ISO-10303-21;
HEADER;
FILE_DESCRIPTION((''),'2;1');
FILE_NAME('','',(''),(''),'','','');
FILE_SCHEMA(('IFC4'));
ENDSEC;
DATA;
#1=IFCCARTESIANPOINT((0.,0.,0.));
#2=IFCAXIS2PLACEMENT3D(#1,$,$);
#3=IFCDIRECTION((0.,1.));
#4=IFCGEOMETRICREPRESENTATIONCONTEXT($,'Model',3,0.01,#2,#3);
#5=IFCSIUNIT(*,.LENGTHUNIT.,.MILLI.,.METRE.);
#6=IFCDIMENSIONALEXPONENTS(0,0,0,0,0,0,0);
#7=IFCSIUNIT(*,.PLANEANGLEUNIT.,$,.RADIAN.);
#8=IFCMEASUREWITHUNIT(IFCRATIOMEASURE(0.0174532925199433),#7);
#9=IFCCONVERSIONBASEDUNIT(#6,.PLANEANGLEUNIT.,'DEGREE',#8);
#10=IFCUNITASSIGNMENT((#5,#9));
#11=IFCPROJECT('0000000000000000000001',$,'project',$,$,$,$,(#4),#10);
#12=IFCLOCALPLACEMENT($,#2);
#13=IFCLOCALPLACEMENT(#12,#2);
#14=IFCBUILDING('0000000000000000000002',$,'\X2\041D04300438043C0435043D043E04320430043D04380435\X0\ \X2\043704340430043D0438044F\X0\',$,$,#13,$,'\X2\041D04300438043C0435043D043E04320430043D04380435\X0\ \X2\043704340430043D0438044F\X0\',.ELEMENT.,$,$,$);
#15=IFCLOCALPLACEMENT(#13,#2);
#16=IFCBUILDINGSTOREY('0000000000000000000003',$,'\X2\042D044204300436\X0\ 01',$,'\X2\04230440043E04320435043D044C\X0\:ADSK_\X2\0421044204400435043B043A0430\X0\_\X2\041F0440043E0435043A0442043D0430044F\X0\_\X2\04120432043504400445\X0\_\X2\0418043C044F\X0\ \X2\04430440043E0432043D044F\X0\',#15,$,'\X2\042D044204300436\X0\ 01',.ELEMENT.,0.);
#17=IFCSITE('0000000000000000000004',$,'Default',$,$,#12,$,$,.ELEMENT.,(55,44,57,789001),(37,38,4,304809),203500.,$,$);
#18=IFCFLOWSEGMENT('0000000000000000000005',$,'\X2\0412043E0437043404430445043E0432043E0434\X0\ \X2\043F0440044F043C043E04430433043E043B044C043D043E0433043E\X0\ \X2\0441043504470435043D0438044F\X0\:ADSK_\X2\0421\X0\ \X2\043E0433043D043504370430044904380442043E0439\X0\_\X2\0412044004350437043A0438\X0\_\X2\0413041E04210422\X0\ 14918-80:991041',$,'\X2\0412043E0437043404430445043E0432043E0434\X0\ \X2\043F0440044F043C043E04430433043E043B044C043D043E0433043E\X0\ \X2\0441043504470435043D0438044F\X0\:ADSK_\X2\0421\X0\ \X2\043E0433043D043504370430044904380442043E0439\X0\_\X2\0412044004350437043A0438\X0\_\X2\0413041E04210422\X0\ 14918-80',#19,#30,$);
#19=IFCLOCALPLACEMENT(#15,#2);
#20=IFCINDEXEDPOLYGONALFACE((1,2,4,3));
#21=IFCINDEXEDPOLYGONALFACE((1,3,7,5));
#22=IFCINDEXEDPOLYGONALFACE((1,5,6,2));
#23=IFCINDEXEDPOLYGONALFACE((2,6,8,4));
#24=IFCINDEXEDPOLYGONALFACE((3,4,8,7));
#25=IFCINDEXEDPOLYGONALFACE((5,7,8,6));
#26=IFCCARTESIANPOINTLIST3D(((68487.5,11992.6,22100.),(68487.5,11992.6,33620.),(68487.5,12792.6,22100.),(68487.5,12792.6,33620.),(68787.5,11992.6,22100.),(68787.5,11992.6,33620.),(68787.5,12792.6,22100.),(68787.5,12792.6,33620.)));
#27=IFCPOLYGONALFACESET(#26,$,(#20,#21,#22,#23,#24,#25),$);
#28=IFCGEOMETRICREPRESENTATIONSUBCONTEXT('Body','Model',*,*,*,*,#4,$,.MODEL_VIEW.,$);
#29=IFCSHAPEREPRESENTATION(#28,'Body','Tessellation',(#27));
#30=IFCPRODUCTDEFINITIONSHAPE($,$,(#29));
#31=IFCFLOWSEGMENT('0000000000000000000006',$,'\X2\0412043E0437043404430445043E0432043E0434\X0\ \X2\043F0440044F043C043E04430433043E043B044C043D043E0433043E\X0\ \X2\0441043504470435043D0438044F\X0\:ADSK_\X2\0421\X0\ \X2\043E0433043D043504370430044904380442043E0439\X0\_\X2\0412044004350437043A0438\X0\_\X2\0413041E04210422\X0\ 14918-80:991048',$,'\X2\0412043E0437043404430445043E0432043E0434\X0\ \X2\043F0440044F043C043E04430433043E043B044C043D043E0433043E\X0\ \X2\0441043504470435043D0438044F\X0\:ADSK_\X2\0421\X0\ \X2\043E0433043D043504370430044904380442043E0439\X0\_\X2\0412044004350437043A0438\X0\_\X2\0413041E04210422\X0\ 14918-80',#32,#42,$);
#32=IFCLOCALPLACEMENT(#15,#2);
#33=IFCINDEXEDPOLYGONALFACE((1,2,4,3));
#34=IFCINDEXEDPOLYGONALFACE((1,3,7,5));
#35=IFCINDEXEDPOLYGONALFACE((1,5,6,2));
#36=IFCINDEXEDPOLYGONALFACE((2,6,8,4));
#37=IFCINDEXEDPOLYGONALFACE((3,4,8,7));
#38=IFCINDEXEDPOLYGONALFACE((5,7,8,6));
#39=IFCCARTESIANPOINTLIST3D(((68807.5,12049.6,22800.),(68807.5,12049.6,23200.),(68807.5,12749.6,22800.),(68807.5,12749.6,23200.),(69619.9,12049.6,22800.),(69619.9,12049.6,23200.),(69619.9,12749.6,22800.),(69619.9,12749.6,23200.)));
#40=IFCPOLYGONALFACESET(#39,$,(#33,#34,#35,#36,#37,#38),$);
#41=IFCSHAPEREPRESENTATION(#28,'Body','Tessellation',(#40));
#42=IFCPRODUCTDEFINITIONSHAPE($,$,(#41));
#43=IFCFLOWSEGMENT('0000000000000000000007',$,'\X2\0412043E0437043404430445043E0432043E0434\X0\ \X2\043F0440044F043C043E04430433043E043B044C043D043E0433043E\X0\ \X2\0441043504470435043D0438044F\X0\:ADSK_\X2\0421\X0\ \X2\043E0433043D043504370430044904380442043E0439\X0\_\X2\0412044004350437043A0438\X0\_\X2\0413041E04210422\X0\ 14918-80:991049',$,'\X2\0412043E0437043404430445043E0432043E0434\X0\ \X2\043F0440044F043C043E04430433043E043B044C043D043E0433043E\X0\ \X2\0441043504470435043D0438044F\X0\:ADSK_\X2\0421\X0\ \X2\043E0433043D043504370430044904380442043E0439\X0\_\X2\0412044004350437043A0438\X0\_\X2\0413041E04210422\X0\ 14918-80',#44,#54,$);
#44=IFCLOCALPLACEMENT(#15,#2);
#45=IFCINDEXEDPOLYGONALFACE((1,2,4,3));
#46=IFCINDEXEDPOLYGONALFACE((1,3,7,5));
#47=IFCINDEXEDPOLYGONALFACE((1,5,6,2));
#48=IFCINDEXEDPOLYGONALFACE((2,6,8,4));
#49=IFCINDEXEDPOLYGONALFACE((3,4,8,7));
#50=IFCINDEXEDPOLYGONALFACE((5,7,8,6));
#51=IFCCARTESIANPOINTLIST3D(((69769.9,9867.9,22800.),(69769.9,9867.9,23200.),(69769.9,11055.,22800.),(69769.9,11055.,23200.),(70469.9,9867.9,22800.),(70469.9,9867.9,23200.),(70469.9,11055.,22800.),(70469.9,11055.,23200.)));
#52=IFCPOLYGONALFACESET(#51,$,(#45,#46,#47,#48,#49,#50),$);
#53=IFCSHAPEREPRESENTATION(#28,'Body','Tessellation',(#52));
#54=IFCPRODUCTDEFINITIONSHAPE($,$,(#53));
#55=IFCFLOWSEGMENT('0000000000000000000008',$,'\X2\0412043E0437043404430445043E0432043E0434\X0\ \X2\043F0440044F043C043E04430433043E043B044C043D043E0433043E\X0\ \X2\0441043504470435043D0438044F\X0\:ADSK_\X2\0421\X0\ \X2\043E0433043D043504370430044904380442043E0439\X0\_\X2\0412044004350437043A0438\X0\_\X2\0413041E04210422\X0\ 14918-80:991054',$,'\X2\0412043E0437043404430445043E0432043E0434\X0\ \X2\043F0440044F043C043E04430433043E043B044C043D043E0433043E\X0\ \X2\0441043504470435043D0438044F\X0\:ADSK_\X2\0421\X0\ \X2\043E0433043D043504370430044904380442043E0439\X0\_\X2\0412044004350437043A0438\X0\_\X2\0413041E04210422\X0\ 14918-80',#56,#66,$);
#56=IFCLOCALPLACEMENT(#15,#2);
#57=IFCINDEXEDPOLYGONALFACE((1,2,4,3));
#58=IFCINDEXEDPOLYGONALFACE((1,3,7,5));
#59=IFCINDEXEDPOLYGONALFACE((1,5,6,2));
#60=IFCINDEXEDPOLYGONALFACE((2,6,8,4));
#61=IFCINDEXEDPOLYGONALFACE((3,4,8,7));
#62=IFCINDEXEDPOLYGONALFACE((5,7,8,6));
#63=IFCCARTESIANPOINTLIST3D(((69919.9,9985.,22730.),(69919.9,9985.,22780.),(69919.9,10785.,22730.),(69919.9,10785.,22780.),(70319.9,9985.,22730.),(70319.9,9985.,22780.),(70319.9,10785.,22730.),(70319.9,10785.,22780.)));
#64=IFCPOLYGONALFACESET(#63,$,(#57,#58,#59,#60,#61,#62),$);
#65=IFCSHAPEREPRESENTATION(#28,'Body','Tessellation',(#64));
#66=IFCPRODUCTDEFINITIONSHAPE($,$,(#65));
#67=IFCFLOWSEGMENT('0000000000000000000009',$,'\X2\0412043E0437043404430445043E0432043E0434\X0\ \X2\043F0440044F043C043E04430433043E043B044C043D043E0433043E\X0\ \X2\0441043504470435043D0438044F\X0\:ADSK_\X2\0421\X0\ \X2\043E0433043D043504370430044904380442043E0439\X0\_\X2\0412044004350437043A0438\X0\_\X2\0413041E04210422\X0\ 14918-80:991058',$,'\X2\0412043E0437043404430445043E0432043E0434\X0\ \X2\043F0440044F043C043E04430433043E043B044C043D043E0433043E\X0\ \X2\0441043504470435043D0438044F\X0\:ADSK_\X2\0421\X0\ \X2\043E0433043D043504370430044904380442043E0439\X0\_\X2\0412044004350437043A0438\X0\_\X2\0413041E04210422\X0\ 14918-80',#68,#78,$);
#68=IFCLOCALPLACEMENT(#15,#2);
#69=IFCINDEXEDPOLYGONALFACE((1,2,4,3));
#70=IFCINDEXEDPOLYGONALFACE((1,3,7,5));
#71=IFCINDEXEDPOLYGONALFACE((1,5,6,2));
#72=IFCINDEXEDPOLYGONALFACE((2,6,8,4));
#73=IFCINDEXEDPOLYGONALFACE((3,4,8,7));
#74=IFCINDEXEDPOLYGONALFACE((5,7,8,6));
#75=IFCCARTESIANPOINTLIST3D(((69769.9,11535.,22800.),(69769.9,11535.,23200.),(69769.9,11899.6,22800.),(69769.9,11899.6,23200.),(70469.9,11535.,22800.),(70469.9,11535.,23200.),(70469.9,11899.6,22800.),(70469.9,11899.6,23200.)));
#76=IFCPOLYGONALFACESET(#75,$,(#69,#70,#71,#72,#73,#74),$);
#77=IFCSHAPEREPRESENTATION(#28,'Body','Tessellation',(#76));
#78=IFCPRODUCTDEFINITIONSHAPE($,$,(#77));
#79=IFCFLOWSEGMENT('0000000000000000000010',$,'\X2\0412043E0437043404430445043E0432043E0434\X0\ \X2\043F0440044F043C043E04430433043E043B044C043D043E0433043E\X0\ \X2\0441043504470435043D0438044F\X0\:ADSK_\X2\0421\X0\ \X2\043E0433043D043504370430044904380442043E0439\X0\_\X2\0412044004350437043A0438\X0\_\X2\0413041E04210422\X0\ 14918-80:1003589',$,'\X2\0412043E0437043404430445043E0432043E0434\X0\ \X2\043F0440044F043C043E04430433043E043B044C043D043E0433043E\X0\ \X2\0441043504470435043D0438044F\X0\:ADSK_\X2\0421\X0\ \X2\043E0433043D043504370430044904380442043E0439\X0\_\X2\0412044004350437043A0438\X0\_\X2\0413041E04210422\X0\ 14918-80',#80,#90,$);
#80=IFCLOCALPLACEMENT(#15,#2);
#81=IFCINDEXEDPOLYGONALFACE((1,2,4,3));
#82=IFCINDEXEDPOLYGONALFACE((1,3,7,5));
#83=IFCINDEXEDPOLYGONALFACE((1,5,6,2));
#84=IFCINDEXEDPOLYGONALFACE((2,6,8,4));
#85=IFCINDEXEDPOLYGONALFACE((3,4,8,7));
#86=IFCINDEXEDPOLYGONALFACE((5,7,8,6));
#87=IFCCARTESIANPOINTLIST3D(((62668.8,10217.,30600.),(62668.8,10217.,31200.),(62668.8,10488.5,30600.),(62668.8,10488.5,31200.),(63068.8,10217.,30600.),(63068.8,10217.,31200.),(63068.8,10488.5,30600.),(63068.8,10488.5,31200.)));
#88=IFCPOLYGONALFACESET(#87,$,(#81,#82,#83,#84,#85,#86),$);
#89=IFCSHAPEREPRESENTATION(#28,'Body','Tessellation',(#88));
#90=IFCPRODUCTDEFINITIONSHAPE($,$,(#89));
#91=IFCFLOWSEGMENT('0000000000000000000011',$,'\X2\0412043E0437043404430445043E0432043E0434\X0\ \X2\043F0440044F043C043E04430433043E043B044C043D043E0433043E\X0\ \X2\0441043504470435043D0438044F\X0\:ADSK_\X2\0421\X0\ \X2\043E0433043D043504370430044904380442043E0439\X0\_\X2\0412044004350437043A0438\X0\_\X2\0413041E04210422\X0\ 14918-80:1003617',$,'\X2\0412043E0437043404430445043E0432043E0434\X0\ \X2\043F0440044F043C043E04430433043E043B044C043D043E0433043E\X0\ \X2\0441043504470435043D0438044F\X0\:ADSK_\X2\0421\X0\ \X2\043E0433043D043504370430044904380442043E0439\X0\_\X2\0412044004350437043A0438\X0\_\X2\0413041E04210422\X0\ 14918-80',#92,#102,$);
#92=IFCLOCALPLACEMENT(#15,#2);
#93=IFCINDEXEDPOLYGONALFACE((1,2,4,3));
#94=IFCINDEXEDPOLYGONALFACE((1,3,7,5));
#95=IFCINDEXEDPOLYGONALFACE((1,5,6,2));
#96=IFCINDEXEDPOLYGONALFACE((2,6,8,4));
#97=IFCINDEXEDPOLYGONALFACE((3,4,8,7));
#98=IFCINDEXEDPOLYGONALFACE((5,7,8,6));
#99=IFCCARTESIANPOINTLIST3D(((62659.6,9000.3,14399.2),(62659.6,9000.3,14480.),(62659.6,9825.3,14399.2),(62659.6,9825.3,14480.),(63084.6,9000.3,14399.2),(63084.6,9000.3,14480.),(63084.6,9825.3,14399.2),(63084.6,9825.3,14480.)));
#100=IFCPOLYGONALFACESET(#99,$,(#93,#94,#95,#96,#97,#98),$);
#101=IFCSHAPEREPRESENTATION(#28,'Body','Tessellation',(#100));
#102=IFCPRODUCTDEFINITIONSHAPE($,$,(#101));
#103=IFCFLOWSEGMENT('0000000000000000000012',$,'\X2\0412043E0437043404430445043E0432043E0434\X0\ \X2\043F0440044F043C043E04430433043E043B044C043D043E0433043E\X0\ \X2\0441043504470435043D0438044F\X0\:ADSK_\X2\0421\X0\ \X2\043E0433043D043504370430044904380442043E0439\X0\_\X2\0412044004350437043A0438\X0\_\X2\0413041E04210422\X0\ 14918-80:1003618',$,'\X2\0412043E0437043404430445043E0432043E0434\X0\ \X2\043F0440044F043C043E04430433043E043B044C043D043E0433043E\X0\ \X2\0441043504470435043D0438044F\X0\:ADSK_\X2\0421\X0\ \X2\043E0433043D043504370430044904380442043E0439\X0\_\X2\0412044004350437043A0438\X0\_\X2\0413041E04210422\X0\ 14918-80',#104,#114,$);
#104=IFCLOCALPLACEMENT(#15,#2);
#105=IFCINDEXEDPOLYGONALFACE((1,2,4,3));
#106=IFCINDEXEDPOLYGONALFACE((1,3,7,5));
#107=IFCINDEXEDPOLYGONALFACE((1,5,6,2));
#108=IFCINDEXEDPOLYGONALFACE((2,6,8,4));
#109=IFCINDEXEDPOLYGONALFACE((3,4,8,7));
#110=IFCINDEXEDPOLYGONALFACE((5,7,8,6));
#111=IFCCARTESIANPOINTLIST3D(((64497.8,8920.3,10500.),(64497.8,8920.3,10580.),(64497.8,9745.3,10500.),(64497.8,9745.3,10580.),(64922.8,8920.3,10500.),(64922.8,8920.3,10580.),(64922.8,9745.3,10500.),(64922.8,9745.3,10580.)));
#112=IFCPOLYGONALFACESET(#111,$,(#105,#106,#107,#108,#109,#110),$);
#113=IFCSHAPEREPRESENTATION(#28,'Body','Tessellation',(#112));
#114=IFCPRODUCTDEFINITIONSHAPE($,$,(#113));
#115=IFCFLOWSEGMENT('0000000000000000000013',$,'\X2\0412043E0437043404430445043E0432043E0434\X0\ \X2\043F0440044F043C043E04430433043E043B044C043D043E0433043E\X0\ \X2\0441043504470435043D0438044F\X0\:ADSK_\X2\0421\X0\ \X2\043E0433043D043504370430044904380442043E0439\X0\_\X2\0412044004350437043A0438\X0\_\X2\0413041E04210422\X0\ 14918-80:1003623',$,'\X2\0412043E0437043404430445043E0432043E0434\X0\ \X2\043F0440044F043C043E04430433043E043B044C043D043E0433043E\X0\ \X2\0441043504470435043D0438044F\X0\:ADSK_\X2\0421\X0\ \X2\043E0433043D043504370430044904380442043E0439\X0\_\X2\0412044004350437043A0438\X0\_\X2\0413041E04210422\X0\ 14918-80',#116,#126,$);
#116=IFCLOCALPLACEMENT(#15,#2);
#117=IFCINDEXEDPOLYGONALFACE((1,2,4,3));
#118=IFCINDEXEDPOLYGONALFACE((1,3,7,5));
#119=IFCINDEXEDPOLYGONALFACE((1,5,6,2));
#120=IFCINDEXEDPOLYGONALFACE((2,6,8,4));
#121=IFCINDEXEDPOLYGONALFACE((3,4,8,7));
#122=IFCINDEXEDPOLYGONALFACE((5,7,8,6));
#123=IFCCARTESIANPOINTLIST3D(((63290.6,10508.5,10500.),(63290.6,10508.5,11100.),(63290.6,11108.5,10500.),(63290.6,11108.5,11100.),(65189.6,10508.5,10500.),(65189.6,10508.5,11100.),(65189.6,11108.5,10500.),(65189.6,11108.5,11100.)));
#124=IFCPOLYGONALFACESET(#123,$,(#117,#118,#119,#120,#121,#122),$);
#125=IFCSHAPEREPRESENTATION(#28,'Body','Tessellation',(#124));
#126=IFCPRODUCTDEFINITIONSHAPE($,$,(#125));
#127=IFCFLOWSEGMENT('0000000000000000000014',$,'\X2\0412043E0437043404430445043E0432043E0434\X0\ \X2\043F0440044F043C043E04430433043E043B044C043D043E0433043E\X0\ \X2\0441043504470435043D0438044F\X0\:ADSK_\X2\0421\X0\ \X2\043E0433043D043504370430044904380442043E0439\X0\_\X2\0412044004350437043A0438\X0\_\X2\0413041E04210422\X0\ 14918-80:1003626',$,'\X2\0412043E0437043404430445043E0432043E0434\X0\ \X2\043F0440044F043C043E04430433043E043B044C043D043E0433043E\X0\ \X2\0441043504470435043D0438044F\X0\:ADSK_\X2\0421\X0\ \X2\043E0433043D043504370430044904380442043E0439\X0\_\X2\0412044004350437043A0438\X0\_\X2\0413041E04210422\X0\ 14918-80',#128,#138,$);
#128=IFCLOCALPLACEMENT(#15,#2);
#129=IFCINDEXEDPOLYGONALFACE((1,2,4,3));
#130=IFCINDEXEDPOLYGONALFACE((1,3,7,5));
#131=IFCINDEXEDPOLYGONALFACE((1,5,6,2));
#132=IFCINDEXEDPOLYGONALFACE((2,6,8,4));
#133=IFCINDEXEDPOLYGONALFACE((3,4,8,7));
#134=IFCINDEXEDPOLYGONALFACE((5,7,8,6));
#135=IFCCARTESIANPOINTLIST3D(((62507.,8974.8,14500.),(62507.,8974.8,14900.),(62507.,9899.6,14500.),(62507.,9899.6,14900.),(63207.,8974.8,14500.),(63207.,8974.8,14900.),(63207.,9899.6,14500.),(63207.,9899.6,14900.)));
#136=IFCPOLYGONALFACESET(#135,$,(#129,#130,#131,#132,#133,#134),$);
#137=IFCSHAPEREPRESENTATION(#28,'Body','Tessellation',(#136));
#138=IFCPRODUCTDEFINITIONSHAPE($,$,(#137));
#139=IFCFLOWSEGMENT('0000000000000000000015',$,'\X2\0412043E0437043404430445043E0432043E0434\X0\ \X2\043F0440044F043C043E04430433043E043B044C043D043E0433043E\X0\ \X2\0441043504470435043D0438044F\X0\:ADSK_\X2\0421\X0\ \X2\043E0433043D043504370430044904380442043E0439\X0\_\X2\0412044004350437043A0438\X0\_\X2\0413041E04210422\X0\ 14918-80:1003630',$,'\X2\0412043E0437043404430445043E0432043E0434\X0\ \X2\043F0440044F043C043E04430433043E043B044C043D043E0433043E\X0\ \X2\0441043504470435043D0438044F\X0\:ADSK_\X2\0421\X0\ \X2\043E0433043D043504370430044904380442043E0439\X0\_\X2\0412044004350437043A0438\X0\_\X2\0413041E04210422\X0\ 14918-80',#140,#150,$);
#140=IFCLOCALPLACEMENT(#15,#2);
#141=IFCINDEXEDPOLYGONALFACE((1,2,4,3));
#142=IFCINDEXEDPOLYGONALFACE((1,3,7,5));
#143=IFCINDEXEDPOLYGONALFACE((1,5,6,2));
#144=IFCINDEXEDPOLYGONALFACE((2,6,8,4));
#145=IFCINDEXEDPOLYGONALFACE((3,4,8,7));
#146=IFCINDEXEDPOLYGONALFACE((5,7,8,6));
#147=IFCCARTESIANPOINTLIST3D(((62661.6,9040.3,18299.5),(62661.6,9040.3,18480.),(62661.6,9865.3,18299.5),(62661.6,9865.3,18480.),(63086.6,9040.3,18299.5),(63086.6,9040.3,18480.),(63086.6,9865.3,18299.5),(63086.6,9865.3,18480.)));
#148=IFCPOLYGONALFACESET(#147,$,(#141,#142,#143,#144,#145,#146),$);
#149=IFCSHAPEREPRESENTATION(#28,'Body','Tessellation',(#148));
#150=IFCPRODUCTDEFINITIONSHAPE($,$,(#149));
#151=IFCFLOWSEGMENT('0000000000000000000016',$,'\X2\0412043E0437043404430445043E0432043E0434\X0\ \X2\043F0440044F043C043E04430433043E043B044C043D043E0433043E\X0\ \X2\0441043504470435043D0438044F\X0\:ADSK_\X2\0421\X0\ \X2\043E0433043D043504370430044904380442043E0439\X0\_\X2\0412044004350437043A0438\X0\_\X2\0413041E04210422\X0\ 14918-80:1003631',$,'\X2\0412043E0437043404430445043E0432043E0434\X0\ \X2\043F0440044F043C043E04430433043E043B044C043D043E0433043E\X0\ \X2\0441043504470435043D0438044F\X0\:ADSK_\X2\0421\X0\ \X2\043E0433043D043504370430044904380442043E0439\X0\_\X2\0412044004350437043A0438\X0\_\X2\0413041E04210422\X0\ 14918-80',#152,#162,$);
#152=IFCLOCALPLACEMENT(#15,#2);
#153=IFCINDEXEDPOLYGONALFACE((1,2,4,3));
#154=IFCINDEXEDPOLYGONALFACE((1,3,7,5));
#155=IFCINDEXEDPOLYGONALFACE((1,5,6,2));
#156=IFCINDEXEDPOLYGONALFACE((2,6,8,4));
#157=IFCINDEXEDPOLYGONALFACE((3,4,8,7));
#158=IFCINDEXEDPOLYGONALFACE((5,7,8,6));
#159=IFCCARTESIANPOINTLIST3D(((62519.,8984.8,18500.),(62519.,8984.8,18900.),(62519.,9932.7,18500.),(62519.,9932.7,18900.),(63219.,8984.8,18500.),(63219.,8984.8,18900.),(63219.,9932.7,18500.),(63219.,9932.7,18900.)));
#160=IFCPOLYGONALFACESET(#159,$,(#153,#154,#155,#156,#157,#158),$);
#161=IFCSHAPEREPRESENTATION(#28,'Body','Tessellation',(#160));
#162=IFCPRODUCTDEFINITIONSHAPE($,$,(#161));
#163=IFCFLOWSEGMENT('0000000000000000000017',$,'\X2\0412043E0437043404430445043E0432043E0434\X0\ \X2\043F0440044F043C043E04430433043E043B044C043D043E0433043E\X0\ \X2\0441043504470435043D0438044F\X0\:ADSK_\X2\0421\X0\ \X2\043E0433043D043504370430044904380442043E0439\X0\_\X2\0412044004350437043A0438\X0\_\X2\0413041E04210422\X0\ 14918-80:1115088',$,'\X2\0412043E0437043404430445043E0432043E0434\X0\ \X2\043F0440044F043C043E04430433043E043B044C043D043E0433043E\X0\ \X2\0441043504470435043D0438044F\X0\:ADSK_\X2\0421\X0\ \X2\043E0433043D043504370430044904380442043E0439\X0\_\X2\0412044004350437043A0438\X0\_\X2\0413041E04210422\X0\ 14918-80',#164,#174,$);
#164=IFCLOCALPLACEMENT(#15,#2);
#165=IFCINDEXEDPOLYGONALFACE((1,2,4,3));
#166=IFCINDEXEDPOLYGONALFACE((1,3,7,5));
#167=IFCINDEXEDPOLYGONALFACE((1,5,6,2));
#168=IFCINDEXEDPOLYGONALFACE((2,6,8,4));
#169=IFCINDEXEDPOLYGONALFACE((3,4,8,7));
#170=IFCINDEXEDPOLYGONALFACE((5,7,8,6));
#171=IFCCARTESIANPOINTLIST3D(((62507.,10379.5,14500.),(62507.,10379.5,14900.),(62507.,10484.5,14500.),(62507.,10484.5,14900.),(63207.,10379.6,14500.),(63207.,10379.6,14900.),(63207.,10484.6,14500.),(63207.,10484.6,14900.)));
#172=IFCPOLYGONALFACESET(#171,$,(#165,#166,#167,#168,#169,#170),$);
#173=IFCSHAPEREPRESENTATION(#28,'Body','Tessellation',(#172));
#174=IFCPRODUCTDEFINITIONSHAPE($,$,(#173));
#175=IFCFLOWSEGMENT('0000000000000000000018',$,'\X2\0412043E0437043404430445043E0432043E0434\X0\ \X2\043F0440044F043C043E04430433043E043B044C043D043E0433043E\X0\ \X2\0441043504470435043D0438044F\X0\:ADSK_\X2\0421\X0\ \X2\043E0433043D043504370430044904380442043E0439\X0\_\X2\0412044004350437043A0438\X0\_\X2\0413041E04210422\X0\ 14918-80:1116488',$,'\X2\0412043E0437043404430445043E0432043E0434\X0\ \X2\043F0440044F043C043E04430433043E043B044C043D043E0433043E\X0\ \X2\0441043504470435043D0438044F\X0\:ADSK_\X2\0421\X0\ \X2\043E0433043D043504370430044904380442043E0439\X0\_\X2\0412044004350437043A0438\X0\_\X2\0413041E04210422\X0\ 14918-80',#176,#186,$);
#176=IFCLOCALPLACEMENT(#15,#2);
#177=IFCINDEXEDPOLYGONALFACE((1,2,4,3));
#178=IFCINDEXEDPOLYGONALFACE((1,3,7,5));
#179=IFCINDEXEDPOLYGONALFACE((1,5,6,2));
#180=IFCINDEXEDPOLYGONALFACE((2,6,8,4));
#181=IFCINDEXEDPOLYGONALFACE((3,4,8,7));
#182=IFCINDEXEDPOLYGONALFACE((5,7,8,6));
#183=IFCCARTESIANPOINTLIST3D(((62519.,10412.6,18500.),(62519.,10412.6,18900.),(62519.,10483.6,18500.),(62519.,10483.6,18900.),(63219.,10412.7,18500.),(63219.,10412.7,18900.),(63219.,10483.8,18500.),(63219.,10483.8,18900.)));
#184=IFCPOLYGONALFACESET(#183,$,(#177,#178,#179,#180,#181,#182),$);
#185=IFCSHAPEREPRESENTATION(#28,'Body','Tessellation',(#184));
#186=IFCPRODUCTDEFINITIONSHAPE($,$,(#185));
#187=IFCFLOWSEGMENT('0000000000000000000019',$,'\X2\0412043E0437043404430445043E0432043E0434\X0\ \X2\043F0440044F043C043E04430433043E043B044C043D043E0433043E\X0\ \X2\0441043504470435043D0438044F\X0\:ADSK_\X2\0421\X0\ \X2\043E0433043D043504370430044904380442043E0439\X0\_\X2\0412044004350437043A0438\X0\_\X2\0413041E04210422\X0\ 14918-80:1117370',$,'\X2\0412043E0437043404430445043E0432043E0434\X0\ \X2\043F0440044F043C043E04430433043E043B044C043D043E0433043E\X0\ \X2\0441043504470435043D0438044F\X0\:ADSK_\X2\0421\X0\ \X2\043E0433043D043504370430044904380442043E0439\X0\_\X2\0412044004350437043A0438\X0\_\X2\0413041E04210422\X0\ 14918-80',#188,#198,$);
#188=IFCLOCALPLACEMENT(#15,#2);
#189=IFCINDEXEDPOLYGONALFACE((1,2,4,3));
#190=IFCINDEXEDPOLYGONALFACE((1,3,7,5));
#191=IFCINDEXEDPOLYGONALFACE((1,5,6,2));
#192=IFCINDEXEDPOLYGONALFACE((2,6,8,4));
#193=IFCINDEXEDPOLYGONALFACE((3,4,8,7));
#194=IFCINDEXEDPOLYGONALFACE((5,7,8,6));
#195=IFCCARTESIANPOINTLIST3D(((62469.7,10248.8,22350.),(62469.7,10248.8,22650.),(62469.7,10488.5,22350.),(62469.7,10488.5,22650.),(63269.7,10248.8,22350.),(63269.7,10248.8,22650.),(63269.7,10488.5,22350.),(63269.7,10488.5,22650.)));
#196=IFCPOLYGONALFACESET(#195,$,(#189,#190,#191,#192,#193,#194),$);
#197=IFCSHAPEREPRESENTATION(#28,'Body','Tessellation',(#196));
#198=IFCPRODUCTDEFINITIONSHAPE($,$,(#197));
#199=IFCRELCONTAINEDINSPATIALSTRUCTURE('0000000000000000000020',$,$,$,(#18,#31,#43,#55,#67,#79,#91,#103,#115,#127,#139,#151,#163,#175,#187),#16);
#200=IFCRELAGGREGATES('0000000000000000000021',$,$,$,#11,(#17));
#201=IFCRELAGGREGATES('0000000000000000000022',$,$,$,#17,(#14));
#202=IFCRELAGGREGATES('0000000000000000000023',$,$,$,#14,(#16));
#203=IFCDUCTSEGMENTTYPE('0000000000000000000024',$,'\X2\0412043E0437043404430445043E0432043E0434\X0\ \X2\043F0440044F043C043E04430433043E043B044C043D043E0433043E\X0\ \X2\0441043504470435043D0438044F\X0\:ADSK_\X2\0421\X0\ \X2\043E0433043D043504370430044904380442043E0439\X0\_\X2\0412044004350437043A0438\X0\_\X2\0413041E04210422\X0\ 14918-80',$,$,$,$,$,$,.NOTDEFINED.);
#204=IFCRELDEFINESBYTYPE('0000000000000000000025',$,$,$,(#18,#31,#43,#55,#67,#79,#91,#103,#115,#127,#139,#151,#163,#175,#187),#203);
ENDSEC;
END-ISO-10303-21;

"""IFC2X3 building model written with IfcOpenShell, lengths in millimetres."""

from ifc_helpers import new_model, entity, si_unit, converted_unit, direction, frame, frame_2d, origin, origin_2d_with_axis, place, context, subcontext, project, spatial, rectangle, extrude, type_object, element, save


model = new_model("IFC2X3")

# Units and contexts
model_context = context("Model", 3, precision=0.01, world=origin(), true_north=direction((0.0, 1.0)))
body_context = subcontext(model_context, "Body", "Model", "MODEL_VIEW")
ifc_project = project(units=[si_unit("LENGTHUNIT", "METRE", prefix="MILLI"), converted_unit("PLANEANGLEUNIT", "DEGREE", entity("IfcRatioMeasure", 0.0174532925199433), si_unit("PLANEANGLEUNIT", "RADIAN"), dimensions=[0, 0, 0, 0, 0, 0, 0])], contexts=[model_context])

# Site, building, storey
site_placement = place(None, frame((0.0, 0.0, 0.0)))
site = spatial("IfcSite", under=ifc_project, at=site_placement, Name="Default", CompositionType="ELEMENT", RefLatitude=(55, 44, 57, 789001), RefLongitude=(37, 38, 4, 304809), RefElevation=203500.0)
building_placement = place(site_placement, origin())
building = spatial("IfcBuilding", under=site, at=building_placement, Name="Наименование здания", LongName="Наименование здания", CompositionType="ELEMENT")
storey_placement = place(building_placement, origin())
storey = spatial("IfcBuildingStorey", under=building, at=storey_placement, Name="Этаж 01", ObjectType="Уровень:ADSK_Стрелка_Проектная_Вверх_Имя уровня", LongName="Этаж 01", CompositionType="ELEMENT", Elevation=0.0)

# Flow segments
duct_segment_type = type_object("IfcDuctSegmentType", Name="Воздуховод прямоугольного сечения:ADSK_С огнезащитой_Врезки_ГОСТ 14918-80", PredefinedType="NOTDEFINED")
flow_segment_1_placement = place(storey_placement, frame((68487.5, 11992.6, 22100.0)))
element("IfcFlowSegment", 1, at=flow_segment_1_placement, inside=storey, type_object=duct_segment_type, Name="Воздуховод прямоугольного сечения:ADSK_С огнезащитой_Врезки_ГОСТ 14918-80:991041", ObjectType="Воздуховод прямоугольного сечения:ADSK_С огнезащитой_Врезки_ГОСТ 14918-80", context=body_context, shape_type="SweptSolid", body=[
    extrude(rectangle(XDim=300.0, YDim=800.0, at=origin_2d_with_axis()), frame((150.0, 400.0, 0.0), z_axis=(0.0, 0.0, 1.0), x_axis=(-1.0, 0.0, 0.0)), (0.0, 0.0, 1.0), 11520.0),
])
flow_segment_2_placement = place(storey_placement, frame((68807.5, 12049.6, 22800.0)))
element("IfcFlowSegment", 2, at=flow_segment_2_placement, inside=storey, type_object=duct_segment_type, Name="Воздуховод прямоугольного сечения:ADSK_С огнезащитой_Врезки_ГОСТ 14918-80:991048", ObjectType="Воздуховод прямоугольного сечения:ADSK_С огнезащитой_Врезки_ГОСТ 14918-80", context=body_context, shape_type="SweptSolid", body=[
    extrude(rectangle(XDim=812.4, YDim=700.0, at=origin_2d_with_axis()), frame((406.2, 350.0, 0.0), z_axis=(0.0, 0.0, 1.0), x_axis=(-1.0, 0.0, 0.0)), (0.0, 0.0, 1.0), 400.0),
])
flow_segment_3_placement = place(storey_placement, frame((69769.9, 9867.9, 22800.0)))
element("IfcFlowSegment", 3, at=flow_segment_3_placement, inside=storey, type_object=duct_segment_type, Name="Воздуховод прямоугольного сечения:ADSK_С огнезащитой_Врезки_ГОСТ 14918-80:991049", ObjectType="Воздуховод прямоугольного сечения:ADSK_С огнезащитой_Врезки_ГОСТ 14918-80", context=body_context, shape_type="SweptSolid", body=[
    extrude(rectangle(XDim=1187.1, YDim=700.0, at=frame_2d((0.0, 0.0), x_axis=(1.0, 0.0))), frame((350.0, 593.5, 0.0), z_axis=(0.0, 0.0, 1.0), x_axis=(0.0, -1.0, 0.0)), (0.0, 0.0, 1.0), 400.0),
])
flow_segment_4_placement = place(storey_placement, frame((69919.9, 9985.0, 22730.0)))
element("IfcFlowSegment", 4, at=flow_segment_4_placement, inside=storey, type_object=duct_segment_type, Name="Воздуховод прямоугольного сечения:ADSK_С огнезащитой_Врезки_ГОСТ 14918-80:991054", ObjectType="Воздуховод прямоугольного сечения:ADSK_С огнезащитой_Врезки_ГОСТ 14918-80", context=body_context, shape_type="SweptSolid", body=[
    extrude(rectangle(XDim=800.0, YDim=400.0, at=origin_2d_with_axis()), frame((200.0, 400.0, 0.0), z_axis=(0.0, 0.0, 1.0), x_axis=(0.0, 1.0, 0.0)), (0.0, 0.0, 1.0), 50.0),
])
flow_segment_5_placement = place(storey_placement, frame((69769.9, 11535.0, 22800.0)))
element("IfcFlowSegment", 5, at=flow_segment_5_placement, inside=storey, type_object=duct_segment_type, Name="Воздуховод прямоугольного сечения:ADSK_С огнезащитой_Врезки_ГОСТ 14918-80:991058", ObjectType="Воздуховод прямоугольного сечения:ADSK_С огнезащитой_Врезки_ГОСТ 14918-80", context=body_context, shape_type="SweptSolid", body=[
    extrude(rectangle(XDim=364.6, YDim=700.0, at=frame_2d((0.0, 0.0), x_axis=(1.0, 0.0))), frame((350.0, 182.3, 0.0), z_axis=(0.0, 0.0, 1.0), x_axis=(0.0, -1.0, 0.0)), (0.0, 0.0, 1.0), 400.0),
])
flow_segment_6_placement = place(storey_placement, frame((62668.8, 10217.0, 30600.0)))
element("IfcFlowSegment", 6, at=flow_segment_6_placement, inside=storey, type_object=duct_segment_type, Name="Воздуховод прямоугольного сечения:ADSK_С огнезащитой_Врезки_ГОСТ 14918-80:1003589", ObjectType="Воздуховод прямоугольного сечения:ADSK_С огнезащитой_Врезки_ГОСТ 14918-80", context=body_context, shape_type="SweptSolid", body=[
    extrude(rectangle(XDim=271.5, YDim=400.0, at=frame_2d((0.0, 0.0), x_axis=(1.0, 0.0))), frame((200.0, 135.7, 0.0), z_axis=(0.0, 0.0, 1.0), x_axis=(0.0, 1.0, 0.0)), (0.0, 0.0, 1.0), 600.0),
])
flow_segment_7_placement = place(storey_placement, frame((62659.6, 9000.3, 14399.2)))
element("IfcFlowSegment", 7, at=flow_segment_7_placement, inside=storey, type_object=duct_segment_type, Name="Воздуховод прямоугольного сечения:ADSK_С огнезащитой_Врезки_ГОСТ 14918-80:1003617", ObjectType="Воздуховод прямоугольного сечения:ADSK_С огнезащитой_Врезки_ГОСТ 14918-80", context=body_context, shape_type="SweptSolid", body=[
    extrude(rectangle(XDim=425.0, YDim=825.0, at=frame_2d((0.0, 0.0), x_axis=(1.0, 0.0))), frame((212.5, 412.5, 0.0)), (0.0, 0.0, 1.0), 80.7),
])
flow_segment_8_placement = place(storey_placement, frame((64497.8, 8920.3, 10500.0)))
element("IfcFlowSegment", 8, at=flow_segment_8_placement, inside=storey, type_object=duct_segment_type, Name="Воздуховод прямоугольного сечения:ADSK_С огнезащитой_Врезки_ГОСТ 14918-80:1003618", ObjectType="Воздуховод прямоугольного сечения:ADSK_С огнезащитой_Врезки_ГОСТ 14918-80", context=body_context, shape_type="SweptSolid", body=[
    extrude(rectangle(XDim=825.0, YDim=425.0, at=frame_2d((0.0, 0.0), x_axis=(1.0, 0.0))), frame((212.5, 412.5, 0.0), z_axis=(0.0, 0.0, 1.0), x_axis=(0.0, 1.0, 0.0)), (0.0, 0.0, 1.0), 80.0),
])
flow_segment_9_placement = place(storey_placement, frame((63290.6, 10508.5, 10500.0)))
element("IfcFlowSegment", 9, at=flow_segment_9_placement, inside=storey, type_object=duct_segment_type, Name="Воздуховод прямоугольного сечения:ADSK_С огнезащитой_Врезки_ГОСТ 14918-80:1003623", ObjectType="Воздуховод прямоугольного сечения:ADSK_С огнезащитой_Врезки_ГОСТ 14918-80", context=body_context, shape_type="SweptSolid", body=[
    extrude(rectangle(XDim=1899.1, YDim=600.0, at=frame_2d((0.0, 0.0), x_axis=(1.0, 0.0))), frame((949.5, 300.0, 0.0)), (0.0, 0.0, 1.0), 600.0),
])
flow_segment_10_placement = place(storey_placement, frame((62507.0, 8974.8, 14500.0)))
element("IfcFlowSegment", 10, at=flow_segment_10_placement, inside=storey, type_object=duct_segment_type, Name="Воздуховод прямоугольного сечения:ADSK_С огнезащитой_Врезки_ГОСТ 14918-80:1003626", ObjectType="Воздуховод прямоугольного сечения:ADSK_С огнезащитой_Врезки_ГОСТ 14918-80", context=body_context, shape_type="SweptSolid", body=[
    extrude(rectangle(XDim=924.8, YDim=700.0, at=frame_2d((0.0, 0.0), x_axis=(1.0, 0.0))), frame((350.0, 462.4, 0.0), z_axis=(0.0, 0.0, 1.0), x_axis=(0.0, -1.0, 0.0)), (0.0, 0.0, 1.0), 400.0),
])
flow_segment_11_placement = place(storey_placement, frame((62661.6, 9040.3, 18299.5)))
element("IfcFlowSegment", 11, at=flow_segment_11_placement, inside=storey, type_object=duct_segment_type, Name="Воздуховод прямоугольного сечения:ADSK_С огнезащитой_Врезки_ГОСТ 14918-80:1003630", ObjectType="Воздуховод прямоугольного сечения:ADSK_С огнезащитой_Врезки_ГОСТ 14918-80", context=body_context, shape_type="SweptSolid", body=[
    extrude(rectangle(XDim=425.0, YDim=825.0, at=frame_2d((0.0, 0.0), x_axis=(1.0, 0.0))), frame((212.5, 412.5, 0.0), z_axis=(0.0, 0.0, 1.0), x_axis=(-1.0, 0.0, 0.0)), (0.0, 0.0, 1.0), 180.5),
])
flow_segment_12_placement = place(storey_placement, frame((62519.0, 8984.8, 18500.0)))
element("IfcFlowSegment", 12, at=flow_segment_12_placement, inside=storey, type_object=duct_segment_type, Name="Воздуховод прямоугольного сечения:ADSK_С огнезащитой_Врезки_ГОСТ 14918-80:1003631", ObjectType="Воздуховод прямоугольного сечения:ADSK_С огнезащитой_Врезки_ГОСТ 14918-80", context=body_context, shape_type="SweptSolid", body=[
    extrude(rectangle(XDim=947.8, YDim=700.0, at=origin_2d_with_axis()), frame((350.0, 473.9, 0.0), z_axis=(0.0, 0.0, 1.0), x_axis=(0.0, 1.0, 0.0)), (0.0, 0.0, 1.0), 400.0),
])
flow_segment_13_placement = place(storey_placement, frame((62507.0, 10379.5, 14500.0)))
element("IfcFlowSegment", 13, at=flow_segment_13_placement, inside=storey, type_object=duct_segment_type, Name="Воздуховод прямоугольного сечения:ADSK_С огнезащитой_Врезки_ГОСТ 14918-80:1115088", ObjectType="Воздуховод прямоугольного сечения:ADSK_С огнезащитой_Врезки_ГОСТ 14918-80", context=body_context, shape_type="SweptSolid", body=[
    extrude(rectangle(XDim=104.9, YDim=700.0, at=frame_2d((0.0, 0.0), x_axis=(1.0, 0.0))), frame((350.0, 52.5, 0.0), z_axis=(0.0, 0.0, 1.0), x_axis=(-0.00013, 1.0, 0.0)), (0.0, 0.0, 1.0), 400.0),
])
flow_segment_14_placement = place(storey_placement, frame((62519.0, 10412.6, 18500.0)))
element("IfcFlowSegment", 14, at=flow_segment_14_placement, inside=storey, type_object=duct_segment_type, Name="Воздуховод прямоугольного сечения:ADSK_С огнезащитой_Врезки_ГОСТ 14918-80:1116488", ObjectType="Воздуховод прямоугольного сечения:ADSK_С огнезащитой_Врезки_ГОСТ 14918-80", context=body_context, shape_type="SweptSolid", body=[
    extrude(rectangle(XDim=71.0, YDim=700.0, at=origin_2d_with_axis()), frame((350.0, 35.6, 0.0), z_axis=(0.0, 0.0, 1.0), x_axis=(-0.000157, 1.0, 0.0)), (0.0, 0.0, 1.0), 400.0),
])
flow_segment_15_placement = place(storey_placement, frame((62469.7, 10248.8, 22350.0)))
element("IfcFlowSegment", 15, at=flow_segment_15_placement, inside=storey, type_object=duct_segment_type, Name="Воздуховод прямоугольного сечения:ADSK_С огнезащитой_Врезки_ГОСТ 14918-80:1117370", ObjectType="Воздуховод прямоугольного сечения:ADSK_С огнезащитой_Врезки_ГОСТ 14918-80", context=body_context, shape_type="SweptSolid", body=[
    extrude(rectangle(XDim=239.7, YDim=800.0, at=frame_2d((0.0, 0.0), x_axis=(1.0, 0.0))), frame((400.0, 119.8, 0.0), z_axis=(0.0, 0.0, 1.0), x_axis=(-0.000003, -1.0, 0.0)), (0.0, 0.0, 1.0), 300.0),
])

save(model, "model.ifc")
